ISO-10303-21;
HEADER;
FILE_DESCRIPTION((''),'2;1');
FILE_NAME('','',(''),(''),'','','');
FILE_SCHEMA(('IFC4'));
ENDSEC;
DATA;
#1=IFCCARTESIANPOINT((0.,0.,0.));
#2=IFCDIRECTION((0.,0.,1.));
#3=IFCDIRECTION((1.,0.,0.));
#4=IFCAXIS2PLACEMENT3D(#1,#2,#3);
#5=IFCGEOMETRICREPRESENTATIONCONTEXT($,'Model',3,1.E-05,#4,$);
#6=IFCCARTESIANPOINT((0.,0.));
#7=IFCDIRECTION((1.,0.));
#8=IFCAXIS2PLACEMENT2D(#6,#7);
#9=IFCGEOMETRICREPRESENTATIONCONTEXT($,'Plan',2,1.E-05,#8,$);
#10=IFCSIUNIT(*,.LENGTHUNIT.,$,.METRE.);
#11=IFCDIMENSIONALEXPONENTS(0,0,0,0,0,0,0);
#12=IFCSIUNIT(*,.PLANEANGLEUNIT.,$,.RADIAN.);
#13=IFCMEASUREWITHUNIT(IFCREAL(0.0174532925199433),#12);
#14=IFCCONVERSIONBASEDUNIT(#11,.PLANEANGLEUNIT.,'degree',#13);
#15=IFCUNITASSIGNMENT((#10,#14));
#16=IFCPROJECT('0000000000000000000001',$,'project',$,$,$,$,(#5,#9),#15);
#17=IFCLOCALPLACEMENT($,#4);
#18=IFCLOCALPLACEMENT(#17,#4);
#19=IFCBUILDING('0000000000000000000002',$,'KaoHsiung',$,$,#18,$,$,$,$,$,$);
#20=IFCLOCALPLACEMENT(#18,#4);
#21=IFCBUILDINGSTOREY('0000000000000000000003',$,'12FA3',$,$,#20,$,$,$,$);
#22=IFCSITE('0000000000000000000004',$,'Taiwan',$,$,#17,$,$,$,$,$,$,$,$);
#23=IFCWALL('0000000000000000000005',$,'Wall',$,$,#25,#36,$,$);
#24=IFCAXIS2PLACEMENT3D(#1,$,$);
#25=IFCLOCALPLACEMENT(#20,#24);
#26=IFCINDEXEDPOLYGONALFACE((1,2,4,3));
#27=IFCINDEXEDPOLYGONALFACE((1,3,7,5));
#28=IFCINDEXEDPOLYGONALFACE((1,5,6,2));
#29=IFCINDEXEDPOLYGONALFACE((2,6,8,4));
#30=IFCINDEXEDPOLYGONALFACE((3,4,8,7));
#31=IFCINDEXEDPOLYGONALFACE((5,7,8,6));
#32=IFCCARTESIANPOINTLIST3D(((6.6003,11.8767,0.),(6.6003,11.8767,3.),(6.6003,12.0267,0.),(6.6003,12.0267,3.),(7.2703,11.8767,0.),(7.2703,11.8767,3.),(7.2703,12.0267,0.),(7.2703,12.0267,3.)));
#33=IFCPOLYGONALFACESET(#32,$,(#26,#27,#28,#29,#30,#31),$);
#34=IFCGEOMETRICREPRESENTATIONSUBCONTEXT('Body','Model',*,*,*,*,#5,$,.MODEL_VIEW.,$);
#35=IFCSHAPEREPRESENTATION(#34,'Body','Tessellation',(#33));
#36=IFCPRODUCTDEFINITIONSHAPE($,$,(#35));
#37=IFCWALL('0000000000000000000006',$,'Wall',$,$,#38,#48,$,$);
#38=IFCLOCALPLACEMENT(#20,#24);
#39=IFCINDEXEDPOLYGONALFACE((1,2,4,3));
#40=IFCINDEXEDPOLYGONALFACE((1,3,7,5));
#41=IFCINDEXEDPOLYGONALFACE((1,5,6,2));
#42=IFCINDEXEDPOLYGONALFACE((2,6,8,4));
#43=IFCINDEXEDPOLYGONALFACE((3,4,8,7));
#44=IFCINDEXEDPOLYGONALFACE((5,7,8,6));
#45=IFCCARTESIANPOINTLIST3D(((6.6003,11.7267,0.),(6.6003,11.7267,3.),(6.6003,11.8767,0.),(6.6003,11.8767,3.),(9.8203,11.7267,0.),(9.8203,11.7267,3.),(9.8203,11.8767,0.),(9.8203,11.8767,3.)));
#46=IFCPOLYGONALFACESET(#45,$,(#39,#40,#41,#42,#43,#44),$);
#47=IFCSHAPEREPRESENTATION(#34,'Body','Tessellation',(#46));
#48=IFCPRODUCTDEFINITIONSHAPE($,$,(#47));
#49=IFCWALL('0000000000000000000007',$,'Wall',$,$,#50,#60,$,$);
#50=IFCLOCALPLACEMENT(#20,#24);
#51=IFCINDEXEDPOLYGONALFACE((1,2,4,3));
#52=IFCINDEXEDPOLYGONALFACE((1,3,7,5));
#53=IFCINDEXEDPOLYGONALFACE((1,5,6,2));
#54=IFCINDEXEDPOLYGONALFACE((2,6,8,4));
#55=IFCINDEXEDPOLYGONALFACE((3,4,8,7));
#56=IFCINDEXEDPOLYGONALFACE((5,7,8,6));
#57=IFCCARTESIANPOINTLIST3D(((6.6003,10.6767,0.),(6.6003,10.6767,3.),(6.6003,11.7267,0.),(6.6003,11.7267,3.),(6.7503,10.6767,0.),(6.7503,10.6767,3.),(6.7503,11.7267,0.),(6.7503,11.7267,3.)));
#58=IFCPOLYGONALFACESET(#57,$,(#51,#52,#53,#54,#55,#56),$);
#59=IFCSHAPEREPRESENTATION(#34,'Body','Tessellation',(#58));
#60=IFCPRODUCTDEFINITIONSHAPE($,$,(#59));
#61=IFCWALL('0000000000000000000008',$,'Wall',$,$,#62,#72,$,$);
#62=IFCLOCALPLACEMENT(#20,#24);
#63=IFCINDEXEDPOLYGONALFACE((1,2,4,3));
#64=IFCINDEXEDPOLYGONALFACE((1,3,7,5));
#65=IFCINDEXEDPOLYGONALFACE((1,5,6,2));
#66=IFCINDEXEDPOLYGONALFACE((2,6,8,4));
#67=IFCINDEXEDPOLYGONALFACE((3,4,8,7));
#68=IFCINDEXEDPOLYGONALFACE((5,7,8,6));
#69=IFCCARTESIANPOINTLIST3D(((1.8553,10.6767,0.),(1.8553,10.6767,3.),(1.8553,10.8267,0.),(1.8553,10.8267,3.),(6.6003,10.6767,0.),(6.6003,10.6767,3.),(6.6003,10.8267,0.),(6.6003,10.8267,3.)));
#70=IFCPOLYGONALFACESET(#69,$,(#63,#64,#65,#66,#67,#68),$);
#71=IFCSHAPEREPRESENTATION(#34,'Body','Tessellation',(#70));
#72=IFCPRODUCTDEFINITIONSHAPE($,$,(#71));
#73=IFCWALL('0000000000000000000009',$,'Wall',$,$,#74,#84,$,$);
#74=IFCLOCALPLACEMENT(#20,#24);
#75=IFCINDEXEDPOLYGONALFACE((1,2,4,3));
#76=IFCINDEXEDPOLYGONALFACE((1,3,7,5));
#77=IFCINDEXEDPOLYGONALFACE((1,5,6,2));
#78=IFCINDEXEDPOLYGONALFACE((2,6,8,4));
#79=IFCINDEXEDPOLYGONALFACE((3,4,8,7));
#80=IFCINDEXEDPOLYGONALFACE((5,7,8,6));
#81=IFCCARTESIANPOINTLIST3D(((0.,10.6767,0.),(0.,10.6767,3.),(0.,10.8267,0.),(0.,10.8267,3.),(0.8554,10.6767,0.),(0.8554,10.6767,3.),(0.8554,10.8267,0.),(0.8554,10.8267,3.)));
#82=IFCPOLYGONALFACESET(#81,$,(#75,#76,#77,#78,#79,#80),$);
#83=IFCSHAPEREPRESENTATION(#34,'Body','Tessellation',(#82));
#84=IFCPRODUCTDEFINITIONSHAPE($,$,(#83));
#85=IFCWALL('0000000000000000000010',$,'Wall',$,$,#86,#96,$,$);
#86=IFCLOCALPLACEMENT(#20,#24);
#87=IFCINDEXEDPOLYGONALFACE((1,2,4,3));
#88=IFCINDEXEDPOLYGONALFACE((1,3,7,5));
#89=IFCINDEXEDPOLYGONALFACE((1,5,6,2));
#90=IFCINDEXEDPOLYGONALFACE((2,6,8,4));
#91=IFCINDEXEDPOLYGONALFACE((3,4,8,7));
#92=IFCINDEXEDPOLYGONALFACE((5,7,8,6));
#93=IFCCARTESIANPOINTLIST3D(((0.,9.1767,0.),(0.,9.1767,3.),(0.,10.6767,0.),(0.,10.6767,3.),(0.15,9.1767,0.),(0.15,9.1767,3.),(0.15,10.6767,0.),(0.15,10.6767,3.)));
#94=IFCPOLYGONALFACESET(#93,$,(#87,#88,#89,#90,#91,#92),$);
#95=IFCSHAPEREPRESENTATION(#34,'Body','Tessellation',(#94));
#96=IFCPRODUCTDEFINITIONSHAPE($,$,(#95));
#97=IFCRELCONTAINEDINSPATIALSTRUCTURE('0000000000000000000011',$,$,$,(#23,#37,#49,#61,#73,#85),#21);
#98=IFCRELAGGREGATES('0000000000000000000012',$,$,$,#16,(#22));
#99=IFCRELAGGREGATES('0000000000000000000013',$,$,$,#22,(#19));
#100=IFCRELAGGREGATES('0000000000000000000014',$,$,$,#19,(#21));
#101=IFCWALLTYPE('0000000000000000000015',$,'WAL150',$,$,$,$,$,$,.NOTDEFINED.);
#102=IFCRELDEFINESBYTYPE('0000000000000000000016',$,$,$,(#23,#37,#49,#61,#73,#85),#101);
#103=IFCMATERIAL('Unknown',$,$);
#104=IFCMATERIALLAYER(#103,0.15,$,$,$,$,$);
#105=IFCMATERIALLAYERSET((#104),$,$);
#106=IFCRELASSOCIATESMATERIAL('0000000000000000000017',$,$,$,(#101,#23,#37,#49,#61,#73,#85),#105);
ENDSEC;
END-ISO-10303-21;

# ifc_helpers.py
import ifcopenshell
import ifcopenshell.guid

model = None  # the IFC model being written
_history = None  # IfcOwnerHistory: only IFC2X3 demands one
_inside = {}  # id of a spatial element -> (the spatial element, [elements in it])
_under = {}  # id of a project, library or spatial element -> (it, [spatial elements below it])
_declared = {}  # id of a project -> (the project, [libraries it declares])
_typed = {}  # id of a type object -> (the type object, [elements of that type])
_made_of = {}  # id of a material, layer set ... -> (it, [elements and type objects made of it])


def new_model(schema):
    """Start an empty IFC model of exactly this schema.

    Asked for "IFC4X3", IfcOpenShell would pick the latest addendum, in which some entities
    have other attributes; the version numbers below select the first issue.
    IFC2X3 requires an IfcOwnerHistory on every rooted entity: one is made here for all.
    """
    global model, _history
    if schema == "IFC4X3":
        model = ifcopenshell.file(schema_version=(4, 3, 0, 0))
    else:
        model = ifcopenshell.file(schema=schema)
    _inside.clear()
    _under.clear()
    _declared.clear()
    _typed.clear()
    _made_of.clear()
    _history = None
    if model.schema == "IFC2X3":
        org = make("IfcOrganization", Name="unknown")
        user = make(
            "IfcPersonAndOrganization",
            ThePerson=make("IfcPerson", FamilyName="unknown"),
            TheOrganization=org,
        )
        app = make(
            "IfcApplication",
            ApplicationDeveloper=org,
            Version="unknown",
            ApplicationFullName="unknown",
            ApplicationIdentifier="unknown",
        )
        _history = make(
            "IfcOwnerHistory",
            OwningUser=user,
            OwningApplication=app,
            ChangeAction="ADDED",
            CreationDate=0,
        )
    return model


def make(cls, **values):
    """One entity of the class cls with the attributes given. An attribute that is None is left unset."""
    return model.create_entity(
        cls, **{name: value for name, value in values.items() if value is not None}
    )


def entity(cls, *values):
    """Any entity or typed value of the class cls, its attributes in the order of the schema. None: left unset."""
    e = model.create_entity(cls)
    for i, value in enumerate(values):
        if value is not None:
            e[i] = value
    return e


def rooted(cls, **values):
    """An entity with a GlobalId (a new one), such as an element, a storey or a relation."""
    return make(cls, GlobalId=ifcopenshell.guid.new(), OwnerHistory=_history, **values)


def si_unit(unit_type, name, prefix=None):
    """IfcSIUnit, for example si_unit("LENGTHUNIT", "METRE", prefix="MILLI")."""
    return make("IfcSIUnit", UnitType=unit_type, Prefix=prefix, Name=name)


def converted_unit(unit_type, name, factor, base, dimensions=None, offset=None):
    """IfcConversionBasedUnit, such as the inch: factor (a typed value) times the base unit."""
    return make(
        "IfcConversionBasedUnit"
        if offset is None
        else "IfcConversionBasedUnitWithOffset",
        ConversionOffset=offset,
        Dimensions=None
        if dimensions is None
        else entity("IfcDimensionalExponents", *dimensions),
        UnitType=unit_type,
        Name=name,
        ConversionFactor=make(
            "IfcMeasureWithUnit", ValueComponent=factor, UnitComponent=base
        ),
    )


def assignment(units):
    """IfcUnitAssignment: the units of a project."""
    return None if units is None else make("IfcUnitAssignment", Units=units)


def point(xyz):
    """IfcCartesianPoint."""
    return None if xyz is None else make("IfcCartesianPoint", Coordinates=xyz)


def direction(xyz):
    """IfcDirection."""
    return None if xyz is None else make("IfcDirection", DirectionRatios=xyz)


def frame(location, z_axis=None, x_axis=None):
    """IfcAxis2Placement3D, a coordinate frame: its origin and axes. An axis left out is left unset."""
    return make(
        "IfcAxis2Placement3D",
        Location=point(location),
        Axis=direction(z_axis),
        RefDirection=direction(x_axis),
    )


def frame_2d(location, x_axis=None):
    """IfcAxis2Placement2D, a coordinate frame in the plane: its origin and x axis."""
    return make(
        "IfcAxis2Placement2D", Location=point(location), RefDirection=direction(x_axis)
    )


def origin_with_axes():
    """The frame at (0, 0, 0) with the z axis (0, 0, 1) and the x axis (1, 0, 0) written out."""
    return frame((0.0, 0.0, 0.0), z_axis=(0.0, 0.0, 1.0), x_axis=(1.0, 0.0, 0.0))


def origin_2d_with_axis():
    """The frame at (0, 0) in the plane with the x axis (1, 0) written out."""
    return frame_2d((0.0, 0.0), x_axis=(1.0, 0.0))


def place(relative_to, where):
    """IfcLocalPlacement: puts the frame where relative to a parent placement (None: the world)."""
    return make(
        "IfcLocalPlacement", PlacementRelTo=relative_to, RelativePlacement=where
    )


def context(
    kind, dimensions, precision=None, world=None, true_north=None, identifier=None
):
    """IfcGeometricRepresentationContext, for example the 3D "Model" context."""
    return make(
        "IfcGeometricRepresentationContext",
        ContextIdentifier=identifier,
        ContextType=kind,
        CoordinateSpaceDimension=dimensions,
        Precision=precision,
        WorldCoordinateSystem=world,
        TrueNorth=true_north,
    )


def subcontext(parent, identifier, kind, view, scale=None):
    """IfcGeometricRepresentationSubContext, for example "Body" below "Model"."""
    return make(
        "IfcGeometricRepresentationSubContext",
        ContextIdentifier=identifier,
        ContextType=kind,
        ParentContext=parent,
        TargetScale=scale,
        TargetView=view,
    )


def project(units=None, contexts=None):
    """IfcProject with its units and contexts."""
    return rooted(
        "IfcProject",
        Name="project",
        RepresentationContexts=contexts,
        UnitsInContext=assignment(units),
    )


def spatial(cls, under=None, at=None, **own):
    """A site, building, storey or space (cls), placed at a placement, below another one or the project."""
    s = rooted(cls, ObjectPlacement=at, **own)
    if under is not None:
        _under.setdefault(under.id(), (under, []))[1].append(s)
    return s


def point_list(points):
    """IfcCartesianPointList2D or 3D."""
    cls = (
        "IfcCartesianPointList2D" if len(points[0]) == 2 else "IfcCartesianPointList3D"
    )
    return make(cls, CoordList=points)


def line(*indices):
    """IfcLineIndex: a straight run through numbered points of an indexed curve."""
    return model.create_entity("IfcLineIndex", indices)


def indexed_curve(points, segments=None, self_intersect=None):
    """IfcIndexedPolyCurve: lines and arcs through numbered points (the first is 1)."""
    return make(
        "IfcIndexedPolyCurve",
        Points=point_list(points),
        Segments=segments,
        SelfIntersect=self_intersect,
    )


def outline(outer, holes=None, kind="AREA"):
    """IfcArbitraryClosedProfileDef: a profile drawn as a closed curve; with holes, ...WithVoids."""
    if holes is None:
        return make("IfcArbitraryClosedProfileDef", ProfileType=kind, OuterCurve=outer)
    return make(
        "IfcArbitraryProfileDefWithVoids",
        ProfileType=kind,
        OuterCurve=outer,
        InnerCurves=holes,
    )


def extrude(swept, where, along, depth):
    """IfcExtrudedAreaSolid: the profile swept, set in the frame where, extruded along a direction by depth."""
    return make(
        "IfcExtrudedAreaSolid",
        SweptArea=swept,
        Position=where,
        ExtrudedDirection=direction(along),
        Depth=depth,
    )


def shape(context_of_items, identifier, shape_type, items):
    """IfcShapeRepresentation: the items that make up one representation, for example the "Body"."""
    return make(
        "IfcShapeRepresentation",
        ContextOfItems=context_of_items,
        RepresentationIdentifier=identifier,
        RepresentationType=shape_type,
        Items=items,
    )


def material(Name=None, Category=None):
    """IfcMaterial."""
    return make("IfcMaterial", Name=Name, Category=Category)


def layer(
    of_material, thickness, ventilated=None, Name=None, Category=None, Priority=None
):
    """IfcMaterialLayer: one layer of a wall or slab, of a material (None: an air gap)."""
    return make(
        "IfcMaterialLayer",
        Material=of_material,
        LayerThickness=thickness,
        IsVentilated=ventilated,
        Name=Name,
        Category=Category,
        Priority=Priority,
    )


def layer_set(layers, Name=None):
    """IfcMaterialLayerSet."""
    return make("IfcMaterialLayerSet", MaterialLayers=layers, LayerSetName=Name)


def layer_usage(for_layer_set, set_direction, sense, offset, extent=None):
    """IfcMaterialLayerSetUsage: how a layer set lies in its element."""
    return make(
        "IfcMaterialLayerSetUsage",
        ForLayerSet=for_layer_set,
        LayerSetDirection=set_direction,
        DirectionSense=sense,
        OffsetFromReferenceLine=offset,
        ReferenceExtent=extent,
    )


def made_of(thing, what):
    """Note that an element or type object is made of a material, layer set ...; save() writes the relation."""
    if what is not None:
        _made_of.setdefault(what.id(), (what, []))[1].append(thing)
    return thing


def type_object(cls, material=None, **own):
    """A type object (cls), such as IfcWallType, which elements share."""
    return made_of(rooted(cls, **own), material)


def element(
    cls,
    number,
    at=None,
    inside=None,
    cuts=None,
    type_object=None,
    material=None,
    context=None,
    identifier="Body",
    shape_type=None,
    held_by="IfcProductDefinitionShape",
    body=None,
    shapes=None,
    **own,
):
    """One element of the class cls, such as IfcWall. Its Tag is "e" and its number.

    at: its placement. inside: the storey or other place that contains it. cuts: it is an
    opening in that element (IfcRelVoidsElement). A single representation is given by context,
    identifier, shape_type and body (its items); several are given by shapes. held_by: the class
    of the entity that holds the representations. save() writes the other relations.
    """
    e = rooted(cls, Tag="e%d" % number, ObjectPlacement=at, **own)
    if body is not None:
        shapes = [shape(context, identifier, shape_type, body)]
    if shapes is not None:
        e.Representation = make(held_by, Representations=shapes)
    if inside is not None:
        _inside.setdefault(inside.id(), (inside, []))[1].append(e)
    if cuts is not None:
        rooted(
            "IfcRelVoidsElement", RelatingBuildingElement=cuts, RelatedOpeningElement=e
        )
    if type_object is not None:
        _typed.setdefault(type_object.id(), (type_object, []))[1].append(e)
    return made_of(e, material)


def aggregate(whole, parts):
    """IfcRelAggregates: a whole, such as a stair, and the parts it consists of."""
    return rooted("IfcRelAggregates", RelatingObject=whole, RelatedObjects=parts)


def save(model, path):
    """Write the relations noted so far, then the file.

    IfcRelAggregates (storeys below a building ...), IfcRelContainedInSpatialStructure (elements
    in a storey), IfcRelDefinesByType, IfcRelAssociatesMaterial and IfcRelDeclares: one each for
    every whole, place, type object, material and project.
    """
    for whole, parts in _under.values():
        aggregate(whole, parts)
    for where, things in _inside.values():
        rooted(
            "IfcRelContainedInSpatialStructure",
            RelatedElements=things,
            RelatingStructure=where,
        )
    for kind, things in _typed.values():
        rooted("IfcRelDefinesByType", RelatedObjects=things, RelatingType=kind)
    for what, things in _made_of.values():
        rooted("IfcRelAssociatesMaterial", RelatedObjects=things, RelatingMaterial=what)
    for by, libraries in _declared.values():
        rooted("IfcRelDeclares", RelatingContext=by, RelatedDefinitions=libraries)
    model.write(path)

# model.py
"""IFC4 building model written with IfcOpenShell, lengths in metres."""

from ifc_helpers import new_model, entity, si_unit, converted_unit, frame, origin_with_axes, origin_2d_with_axis, place, context, subcontext, project, spatial, line, indexed_curve, outline, extrude, material, layer, layer_set, layer_usage, type_object, element, save


model = new_model("IFC4")

# Units and contexts
model_context = context("Model", 3, precision=1e-05, world=origin_with_axes())
plan_context = context("Plan", 2, precision=1e-05, world=origin_2d_with_axis())
body_context = subcontext(model_context, "Body", "Model", "MODEL_VIEW")
ifc_project = project(units=[si_unit("LENGTHUNIT", "METRE"), converted_unit("PLANEANGLEUNIT", "degree", entity("IfcReal", 0.0174532925199433), si_unit("PLANEANGLEUNIT", "RADIAN"), dimensions=[0, 0, 0, 0, 0, 0, 0])], contexts=[model_context, plan_context])

# Site, building, storey
site_placement = place(None, origin_with_axes())
site = spatial("IfcSite", under=ifc_project, at=site_placement, Name="Taiwan")
building_placement = place(site_placement, origin_with_axes())
building = spatial("IfcBuilding", under=site, at=building_placement, Name="KaoHsiung")
storey_placement = place(building_placement, origin_with_axes())
storey = spatial("IfcBuildingStorey", under=building, at=storey_placement, Name="12FA3")

# Shared definitions
ifc_material = material(Name="Unknown")

# Walls
ifc_layer_1 = layer(ifc_material, 0.15)
ifc_layer_set_1 = layer_set([ifc_layer_1])
wall_type_1 = type_object("IfcWallType", Name="WAL150", PredefinedType="NOTDEFINED", material=ifc_layer_set_1)
ifc_layer_usage_1 = layer_usage(ifc_layer_set_1, "AXIS2", "POSITIVE", 0.0)
wall_1_placement = place(storey_placement, frame((7.2703, 12.0267, 0.0), z_axis=(0.0, 0.0, 1.0), x_axis=(-1.0, 0.0, 0.0)))
element("IfcWall", 1, at=wall_1_placement, inside=storey, type_object=wall_type_1, material=ifc_layer_usage_1, Name="Wall", context=body_context, shape_type="SweptSolid", body=[
    extrude(outline(indexed_curve([(0.0, 0.0), (0.0, 0.15), (0.67, 0.15), (0.67, 0.0)], segments=[line(1, 2, 3, 4, 1)])), origin_with_axes(), (0.0, 0.0, 1.0), 3.0),
])
ifc_layer_usage_2 = layer_usage(ifc_layer_set_1, "AXIS2", "POSITIVE", 0.0)
wall_2_placement = place(storey_placement, frame((9.8203, 11.8767, 0.0), z_axis=(0.0, 0.0, 1.0), x_axis=(-1.0, 0.0, 0.0)))
element("IfcWall", 2, at=wall_2_placement, inside=storey, type_object=wall_type_1, material=ifc_layer_usage_2, Name="Wall", context=body_context, shape_type="SweptSolid", body=[
    extrude(outline(indexed_curve([(0.0, 0.0), (0.0, 0.15), (3.22, 0.15), (3.22, 0.0)], segments=[line(1, 2, 3, 4, 1)])), origin_with_axes(), (0.0, 0.0, 1.0), 3.0),
])
ifc_layer_usage_3 = layer_usage(ifc_layer_set_1, "AXIS2", "POSITIVE", 0.0)
wall_3_placement = place(storey_placement, frame((6.6003, 11.7267, 0.0), z_axis=(0.0, 0.0, 1.0), x_axis=(0.0, -1.0, 0.0)))
element("IfcWall", 3, at=wall_3_placement, inside=storey, type_object=wall_type_1, material=ifc_layer_usage_3, Name="Wall", context=body_context, shape_type="SweptSolid", body=[
    extrude(outline(indexed_curve([(0.0, 0.0), (0.0, 0.15), (1.05, 0.15), (1.05, 0.0)], segments=[line(1, 2, 3, 4, 1)])), origin_with_axes(), (0.0, 0.0, 1.0), 3.0),
])
ifc_layer_usage_4 = layer_usage(ifc_layer_set_1, "AXIS2", "POSITIVE", 0.0)
wall_4_placement = place(storey_placement, frame((6.6003, 10.8267, 0.0), z_axis=(0.0, 0.0, 1.0), x_axis=(-1.0, 0.0, 0.0)))
element("IfcWall", 4, at=wall_4_placement, inside=storey, type_object=wall_type_1, material=ifc_layer_usage_4, Name="Wall", context=body_context, shape_type="SweptSolid", body=[
    extrude(outline(indexed_curve([(0.0, 0.0), (0.0, 0.15), (4.745, 0.15), (4.745, 0.0)], segments=[line(1, 2, 3, 4, 1)])), origin_with_axes(), (0.0, 0.0, 1.0), 3.0),
])
ifc_layer_usage_5 = layer_usage(ifc_layer_set_1, "AXIS2", "POSITIVE", 0.0)
wall_5_placement = place(storey_placement, frame((0.8554, 10.8267, 0.0), z_axis=(0.0, 0.0, 1.0), x_axis=(-1.0, 0.0, 0.0)))
element("IfcWall", 5, at=wall_5_placement, inside=storey, type_object=wall_type_1, material=ifc_layer_usage_5, Name="Wall", context=body_context, shape_type="SweptSolid", body=[
    extrude(outline(indexed_curve([(0.0, 0.0), (0.0, 0.15), (0.8553, 0.15), (0.8553, 0.0)], segments=[line(1, 2, 3, 4, 1)])), origin_with_axes(), (0.0, 0.0, 1.0), 3.0),
])
ifc_layer_usage_6 = layer_usage(ifc_layer_set_1, "AXIS2", "POSITIVE", 0.0)
wall_6_placement = place(storey_placement, frame((0.0, 10.6767, 0.0), z_axis=(0.0, 0.0, 1.0), x_axis=(0.0, -1.0, 0.0)))
element("IfcWall", 6, at=wall_6_placement, inside=storey, type_object=wall_type_1, material=ifc_layer_usage_6, Name="Wall", context=body_context, shape_type="SweptSolid", body=[
    extrude(outline(indexed_curve([(0.0, 0.0), (0.0, 0.15), (1.5, 0.15), (1.5, 0.0)], segments=[line(1, 2, 3, 4, 1)])), origin_with_axes(), (0.0, 0.0, 1.0), 3.0),
])

save(model, "model.ifc")
